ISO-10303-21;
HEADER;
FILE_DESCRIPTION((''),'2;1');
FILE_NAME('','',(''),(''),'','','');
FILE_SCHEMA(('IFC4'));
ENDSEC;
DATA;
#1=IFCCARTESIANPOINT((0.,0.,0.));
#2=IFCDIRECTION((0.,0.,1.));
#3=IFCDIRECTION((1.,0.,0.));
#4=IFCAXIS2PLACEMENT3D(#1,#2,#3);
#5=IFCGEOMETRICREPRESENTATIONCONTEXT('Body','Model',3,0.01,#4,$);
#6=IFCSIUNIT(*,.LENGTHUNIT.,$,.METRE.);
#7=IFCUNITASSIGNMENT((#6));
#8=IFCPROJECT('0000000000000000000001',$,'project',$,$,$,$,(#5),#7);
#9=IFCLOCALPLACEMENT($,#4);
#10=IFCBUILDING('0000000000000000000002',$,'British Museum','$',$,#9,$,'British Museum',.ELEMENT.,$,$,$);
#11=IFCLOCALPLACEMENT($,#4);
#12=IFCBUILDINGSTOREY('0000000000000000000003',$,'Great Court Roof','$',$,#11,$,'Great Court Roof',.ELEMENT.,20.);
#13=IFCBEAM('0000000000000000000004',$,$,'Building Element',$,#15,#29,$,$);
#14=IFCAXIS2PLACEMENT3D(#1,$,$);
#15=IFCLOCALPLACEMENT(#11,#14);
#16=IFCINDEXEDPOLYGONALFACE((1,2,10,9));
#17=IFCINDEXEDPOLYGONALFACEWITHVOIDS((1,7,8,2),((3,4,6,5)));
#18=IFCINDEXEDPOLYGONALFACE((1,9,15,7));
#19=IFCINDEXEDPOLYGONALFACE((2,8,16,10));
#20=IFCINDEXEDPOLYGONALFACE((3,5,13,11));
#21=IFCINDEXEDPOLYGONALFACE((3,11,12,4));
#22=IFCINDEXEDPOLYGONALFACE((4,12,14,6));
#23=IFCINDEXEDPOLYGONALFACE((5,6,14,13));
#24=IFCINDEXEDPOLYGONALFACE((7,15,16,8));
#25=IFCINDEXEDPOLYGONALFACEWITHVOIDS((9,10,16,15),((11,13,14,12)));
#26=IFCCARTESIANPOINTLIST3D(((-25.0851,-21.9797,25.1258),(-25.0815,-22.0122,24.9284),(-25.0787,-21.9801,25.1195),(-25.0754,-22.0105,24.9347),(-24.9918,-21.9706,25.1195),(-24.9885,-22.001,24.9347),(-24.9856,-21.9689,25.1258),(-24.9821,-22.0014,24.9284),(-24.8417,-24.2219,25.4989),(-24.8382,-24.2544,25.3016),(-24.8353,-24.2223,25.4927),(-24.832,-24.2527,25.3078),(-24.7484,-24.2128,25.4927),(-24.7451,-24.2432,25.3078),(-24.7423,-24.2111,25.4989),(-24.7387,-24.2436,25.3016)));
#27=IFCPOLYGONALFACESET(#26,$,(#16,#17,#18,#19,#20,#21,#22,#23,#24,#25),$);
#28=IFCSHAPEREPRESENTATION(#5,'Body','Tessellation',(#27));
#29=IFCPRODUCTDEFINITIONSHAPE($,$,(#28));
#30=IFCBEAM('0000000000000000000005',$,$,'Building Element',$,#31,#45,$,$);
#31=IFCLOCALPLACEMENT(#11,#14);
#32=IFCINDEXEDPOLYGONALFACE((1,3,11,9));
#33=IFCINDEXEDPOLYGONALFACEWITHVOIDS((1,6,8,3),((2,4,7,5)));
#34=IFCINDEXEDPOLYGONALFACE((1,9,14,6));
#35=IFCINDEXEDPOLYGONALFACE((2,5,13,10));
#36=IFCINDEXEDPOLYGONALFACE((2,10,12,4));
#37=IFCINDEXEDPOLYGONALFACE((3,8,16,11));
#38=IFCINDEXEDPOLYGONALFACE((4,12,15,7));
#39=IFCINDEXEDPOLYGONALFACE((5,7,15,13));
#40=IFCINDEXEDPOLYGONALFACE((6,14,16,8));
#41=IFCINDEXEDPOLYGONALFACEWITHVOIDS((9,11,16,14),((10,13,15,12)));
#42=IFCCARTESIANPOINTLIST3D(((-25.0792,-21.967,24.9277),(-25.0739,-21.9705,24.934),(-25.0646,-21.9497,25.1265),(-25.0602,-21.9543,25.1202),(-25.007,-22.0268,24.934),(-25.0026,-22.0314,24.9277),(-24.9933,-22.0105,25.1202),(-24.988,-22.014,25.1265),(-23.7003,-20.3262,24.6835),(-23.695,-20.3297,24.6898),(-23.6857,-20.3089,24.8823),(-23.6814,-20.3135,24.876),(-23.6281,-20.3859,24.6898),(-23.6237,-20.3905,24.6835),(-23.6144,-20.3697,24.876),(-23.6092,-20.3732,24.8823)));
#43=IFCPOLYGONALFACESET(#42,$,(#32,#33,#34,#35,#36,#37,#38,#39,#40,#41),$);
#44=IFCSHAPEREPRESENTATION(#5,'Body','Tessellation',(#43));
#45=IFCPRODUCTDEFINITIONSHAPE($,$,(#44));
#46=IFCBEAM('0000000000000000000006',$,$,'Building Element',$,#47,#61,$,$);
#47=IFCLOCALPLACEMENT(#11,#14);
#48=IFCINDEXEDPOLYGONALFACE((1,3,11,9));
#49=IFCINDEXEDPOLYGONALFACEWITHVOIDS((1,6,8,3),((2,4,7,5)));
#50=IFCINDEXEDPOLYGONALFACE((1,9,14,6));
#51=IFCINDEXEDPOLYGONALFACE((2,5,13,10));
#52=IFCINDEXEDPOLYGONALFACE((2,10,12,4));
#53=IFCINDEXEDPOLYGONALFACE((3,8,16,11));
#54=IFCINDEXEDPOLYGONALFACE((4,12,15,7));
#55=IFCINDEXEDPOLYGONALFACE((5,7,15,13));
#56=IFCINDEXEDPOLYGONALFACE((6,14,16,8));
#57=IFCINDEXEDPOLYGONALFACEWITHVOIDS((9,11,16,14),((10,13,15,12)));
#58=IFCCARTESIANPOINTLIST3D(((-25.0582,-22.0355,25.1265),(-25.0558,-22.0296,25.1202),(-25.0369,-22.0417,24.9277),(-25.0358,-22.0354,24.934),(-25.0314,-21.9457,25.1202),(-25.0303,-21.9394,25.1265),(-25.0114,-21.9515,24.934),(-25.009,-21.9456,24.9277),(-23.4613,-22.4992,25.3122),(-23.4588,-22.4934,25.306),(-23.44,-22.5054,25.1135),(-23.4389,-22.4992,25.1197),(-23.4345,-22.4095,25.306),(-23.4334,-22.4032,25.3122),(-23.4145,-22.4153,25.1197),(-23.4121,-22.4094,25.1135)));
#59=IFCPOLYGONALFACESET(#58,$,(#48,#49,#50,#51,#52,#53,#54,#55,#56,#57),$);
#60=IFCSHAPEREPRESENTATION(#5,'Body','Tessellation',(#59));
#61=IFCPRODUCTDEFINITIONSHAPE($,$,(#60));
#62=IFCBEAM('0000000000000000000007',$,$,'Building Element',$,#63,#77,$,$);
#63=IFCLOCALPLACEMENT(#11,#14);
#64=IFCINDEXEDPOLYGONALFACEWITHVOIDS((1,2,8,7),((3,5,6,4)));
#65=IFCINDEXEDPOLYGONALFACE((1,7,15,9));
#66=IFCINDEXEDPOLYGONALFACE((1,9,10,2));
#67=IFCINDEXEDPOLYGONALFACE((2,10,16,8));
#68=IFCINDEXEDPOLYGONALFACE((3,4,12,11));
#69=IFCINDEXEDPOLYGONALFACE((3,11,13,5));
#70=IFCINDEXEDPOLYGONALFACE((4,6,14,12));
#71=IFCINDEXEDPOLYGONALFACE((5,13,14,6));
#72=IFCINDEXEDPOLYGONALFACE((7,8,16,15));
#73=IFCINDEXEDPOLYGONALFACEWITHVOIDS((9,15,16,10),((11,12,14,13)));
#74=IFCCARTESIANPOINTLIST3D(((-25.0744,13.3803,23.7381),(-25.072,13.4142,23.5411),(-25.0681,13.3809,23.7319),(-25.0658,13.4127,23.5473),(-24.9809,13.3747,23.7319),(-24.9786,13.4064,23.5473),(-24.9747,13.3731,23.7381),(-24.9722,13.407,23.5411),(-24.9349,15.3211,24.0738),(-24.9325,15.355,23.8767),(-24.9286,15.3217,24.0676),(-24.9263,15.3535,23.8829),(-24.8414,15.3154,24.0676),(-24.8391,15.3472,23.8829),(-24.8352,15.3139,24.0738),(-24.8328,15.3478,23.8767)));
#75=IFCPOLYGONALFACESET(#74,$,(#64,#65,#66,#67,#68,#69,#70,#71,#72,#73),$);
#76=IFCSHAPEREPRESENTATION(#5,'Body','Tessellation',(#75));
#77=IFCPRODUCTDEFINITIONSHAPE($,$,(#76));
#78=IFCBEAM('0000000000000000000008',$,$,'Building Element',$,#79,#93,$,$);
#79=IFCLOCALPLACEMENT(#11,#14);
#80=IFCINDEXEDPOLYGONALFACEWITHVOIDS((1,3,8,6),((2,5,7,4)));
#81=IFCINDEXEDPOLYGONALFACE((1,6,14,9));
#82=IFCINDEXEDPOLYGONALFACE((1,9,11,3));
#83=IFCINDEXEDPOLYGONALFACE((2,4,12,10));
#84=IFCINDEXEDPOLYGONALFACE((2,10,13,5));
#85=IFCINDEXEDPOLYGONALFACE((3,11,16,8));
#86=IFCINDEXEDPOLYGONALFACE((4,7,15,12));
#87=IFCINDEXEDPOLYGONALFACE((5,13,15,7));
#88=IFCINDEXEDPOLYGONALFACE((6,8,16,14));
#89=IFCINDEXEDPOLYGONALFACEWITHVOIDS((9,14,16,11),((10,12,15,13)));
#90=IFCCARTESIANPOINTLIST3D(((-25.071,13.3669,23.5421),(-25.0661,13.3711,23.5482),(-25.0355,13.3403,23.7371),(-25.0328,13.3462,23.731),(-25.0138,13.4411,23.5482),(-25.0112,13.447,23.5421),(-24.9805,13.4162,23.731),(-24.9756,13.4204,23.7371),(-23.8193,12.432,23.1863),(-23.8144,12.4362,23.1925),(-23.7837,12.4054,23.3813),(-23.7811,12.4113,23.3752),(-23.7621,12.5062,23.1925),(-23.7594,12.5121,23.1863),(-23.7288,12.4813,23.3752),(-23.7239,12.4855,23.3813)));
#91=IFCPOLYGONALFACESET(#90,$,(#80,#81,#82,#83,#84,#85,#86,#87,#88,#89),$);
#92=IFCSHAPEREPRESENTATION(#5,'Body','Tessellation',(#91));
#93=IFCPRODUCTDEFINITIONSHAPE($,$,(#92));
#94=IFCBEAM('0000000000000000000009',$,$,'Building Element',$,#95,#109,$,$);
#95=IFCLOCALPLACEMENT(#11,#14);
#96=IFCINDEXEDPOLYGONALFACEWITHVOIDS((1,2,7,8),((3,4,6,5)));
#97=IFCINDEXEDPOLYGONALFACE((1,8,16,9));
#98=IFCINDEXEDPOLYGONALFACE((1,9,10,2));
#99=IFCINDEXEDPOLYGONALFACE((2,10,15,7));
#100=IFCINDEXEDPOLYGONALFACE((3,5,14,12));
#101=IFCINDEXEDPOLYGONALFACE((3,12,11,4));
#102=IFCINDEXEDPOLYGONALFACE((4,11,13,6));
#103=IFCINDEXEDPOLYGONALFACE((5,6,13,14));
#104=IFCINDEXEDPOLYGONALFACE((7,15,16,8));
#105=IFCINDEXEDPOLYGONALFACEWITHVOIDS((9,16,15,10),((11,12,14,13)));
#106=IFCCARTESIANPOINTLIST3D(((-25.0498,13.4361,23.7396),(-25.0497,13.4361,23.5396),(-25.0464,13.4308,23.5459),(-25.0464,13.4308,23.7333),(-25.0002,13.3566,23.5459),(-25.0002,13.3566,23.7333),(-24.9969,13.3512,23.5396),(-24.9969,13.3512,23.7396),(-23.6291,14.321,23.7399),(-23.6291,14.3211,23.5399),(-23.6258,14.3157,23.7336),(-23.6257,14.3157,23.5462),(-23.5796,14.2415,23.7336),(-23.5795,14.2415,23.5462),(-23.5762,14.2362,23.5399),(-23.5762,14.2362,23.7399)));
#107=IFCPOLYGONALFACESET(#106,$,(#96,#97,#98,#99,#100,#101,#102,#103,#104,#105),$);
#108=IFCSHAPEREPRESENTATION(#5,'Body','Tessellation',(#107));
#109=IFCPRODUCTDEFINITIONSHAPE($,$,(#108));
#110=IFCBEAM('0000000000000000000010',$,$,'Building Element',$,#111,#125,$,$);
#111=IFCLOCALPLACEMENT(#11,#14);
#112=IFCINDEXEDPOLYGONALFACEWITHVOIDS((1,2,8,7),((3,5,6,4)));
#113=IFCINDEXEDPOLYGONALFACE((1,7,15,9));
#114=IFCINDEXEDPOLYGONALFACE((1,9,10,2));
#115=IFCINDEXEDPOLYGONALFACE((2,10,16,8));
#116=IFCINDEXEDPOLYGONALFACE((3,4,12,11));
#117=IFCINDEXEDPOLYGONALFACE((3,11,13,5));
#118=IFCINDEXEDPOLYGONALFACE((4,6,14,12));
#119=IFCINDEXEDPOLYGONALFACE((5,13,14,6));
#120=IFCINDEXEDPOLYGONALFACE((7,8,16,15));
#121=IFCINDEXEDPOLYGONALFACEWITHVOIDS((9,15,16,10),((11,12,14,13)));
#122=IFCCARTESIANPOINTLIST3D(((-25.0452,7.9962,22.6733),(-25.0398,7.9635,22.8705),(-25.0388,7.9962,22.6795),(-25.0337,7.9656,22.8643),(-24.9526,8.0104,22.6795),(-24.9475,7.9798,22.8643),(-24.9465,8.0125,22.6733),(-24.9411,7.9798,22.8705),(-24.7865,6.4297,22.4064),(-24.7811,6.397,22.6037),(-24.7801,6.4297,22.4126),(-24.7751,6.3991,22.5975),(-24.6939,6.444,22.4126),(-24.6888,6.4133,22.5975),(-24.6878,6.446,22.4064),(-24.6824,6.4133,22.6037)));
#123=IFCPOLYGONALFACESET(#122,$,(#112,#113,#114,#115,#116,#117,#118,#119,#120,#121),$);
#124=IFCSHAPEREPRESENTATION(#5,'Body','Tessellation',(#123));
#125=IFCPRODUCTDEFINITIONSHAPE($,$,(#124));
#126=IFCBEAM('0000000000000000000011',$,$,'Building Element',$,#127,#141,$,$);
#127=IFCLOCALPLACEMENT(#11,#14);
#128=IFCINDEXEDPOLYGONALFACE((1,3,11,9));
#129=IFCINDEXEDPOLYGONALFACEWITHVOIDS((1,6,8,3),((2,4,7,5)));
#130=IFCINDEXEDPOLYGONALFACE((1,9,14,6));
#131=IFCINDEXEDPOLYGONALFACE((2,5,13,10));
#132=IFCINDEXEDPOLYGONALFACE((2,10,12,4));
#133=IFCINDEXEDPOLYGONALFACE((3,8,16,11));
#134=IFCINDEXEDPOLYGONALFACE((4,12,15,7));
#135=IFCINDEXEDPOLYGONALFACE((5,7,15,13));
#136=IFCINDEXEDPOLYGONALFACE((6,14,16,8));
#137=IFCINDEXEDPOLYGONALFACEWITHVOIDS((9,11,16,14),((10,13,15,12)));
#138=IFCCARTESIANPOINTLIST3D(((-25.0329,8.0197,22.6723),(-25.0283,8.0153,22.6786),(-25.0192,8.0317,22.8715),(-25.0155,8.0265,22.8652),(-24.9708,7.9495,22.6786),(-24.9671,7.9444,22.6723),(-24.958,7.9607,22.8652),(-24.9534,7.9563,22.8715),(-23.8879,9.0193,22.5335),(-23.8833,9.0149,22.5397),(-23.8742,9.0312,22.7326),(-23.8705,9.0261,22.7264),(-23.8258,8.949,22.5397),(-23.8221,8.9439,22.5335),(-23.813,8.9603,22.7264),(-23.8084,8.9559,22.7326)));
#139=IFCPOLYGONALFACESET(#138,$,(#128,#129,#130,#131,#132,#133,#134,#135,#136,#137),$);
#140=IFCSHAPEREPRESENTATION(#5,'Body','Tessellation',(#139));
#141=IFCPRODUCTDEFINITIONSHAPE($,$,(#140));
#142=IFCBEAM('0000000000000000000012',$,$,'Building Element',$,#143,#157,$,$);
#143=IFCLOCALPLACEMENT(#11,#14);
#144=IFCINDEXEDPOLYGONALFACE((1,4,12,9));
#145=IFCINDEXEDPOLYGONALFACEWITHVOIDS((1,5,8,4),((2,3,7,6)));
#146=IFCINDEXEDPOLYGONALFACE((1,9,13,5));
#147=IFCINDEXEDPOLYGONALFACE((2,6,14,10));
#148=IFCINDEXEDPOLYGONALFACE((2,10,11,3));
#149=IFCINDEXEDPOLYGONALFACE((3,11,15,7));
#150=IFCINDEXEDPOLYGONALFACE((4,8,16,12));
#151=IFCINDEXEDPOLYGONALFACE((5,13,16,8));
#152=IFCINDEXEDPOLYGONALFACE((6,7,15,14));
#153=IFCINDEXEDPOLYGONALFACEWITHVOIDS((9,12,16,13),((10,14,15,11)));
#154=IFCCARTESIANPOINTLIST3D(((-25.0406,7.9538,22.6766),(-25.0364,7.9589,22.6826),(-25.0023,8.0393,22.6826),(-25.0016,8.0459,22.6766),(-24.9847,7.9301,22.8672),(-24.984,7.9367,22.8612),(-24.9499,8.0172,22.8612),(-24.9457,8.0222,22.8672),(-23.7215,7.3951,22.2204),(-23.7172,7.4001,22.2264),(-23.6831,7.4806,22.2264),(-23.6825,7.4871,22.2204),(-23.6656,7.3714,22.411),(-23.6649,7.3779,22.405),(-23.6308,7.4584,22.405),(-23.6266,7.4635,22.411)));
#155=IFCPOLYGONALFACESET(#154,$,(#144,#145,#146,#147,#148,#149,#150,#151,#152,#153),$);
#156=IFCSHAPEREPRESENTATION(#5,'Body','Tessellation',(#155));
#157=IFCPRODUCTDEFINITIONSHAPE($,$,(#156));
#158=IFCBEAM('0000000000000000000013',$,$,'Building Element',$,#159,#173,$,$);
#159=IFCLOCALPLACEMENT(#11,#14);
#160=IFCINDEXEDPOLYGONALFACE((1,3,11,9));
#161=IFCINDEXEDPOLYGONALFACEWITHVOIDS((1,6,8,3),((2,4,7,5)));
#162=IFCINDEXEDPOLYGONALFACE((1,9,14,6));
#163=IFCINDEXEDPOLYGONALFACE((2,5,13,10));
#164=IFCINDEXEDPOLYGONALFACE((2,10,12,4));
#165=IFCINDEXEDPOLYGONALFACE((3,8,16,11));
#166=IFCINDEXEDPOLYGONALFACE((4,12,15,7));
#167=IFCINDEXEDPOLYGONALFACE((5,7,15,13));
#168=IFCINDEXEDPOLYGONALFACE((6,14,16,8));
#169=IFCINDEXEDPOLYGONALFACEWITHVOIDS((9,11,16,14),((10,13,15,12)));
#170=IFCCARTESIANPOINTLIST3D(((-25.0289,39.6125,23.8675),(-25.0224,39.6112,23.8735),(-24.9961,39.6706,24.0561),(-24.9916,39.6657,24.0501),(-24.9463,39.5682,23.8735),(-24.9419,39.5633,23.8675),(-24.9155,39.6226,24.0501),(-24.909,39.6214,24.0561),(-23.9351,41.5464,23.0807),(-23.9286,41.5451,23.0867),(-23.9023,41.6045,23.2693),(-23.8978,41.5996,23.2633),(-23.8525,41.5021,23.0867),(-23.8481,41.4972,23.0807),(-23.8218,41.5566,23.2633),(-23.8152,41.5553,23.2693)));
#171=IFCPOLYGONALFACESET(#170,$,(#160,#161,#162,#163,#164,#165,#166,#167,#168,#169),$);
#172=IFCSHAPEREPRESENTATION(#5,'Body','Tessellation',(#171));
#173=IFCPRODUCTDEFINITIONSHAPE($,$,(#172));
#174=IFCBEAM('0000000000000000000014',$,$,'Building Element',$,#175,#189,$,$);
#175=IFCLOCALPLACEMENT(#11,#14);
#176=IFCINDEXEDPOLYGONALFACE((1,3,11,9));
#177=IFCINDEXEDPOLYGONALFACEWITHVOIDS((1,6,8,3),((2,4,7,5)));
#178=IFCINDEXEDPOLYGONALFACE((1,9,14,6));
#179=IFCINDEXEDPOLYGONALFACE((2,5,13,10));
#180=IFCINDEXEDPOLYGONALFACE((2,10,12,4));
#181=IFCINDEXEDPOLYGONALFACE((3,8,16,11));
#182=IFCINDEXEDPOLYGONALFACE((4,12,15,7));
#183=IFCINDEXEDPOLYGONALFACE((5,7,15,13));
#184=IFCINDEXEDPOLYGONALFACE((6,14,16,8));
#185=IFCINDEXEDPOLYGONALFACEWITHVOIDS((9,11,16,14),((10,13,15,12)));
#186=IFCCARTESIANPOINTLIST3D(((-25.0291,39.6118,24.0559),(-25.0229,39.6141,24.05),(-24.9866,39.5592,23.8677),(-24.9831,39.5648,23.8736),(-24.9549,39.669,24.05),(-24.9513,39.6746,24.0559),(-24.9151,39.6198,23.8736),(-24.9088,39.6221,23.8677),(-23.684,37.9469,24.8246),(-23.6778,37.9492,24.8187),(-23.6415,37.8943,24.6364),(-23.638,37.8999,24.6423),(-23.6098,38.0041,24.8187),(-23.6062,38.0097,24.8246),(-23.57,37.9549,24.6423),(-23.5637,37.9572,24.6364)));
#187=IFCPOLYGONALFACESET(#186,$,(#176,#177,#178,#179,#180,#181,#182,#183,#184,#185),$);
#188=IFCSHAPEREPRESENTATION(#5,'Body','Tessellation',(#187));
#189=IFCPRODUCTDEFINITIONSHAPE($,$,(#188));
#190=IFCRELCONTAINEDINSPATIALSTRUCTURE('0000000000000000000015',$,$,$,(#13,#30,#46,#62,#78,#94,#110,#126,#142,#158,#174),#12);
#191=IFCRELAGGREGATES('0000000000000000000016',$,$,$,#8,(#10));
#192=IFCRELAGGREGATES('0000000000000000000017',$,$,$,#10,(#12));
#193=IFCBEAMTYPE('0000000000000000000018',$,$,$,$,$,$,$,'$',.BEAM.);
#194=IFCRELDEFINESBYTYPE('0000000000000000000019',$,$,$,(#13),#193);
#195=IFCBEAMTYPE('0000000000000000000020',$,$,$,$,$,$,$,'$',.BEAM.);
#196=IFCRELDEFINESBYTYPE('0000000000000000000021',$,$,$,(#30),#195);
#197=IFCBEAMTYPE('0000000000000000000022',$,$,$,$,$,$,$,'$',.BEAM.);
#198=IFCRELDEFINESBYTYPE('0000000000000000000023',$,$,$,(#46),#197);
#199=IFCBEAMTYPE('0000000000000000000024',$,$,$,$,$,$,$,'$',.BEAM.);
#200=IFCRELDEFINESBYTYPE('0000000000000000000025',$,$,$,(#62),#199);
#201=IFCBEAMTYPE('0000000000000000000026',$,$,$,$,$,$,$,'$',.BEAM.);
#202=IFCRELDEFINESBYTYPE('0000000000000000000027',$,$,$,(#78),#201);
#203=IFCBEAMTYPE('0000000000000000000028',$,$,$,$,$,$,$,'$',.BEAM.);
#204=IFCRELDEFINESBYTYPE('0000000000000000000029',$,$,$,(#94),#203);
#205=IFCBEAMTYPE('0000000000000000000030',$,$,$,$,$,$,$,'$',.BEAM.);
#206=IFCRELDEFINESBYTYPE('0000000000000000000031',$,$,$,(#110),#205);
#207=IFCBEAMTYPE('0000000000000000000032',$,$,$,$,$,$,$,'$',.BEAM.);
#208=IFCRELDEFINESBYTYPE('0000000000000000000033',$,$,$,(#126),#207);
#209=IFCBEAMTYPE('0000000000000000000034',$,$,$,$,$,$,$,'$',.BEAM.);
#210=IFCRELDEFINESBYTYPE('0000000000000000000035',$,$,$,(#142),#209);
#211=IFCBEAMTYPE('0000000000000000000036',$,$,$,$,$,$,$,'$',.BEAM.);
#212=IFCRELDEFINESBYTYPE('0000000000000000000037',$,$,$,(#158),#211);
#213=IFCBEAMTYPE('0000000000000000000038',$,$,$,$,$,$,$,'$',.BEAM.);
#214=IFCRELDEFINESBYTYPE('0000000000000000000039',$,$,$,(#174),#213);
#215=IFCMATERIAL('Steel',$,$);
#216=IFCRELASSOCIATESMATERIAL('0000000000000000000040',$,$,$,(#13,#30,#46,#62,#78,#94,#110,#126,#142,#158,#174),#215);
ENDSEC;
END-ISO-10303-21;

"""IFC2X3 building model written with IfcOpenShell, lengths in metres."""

from ifc_helpers import new_model, si_unit, frame, origin_with_axes, origin_2d, place, context, project, spatial, hollow_rectangle, extrude, material, type_object, element, save


model = new_model("IFC2X3")

# Units and contexts
model_context = context("Model", 3, precision=0.01, world=origin_with_axes(), identifier="Body")
ifc_project = project(units=[si_unit("LENGTHUNIT", "METRE")], contexts=[model_context])

# Building, storey
building_placement = place(None, origin_with_axes())
building = spatial("IfcBuilding", under=ifc_project, at=building_placement, Name="British Museum", Description="$", LongName="British Museum", CompositionType="ELEMENT")
storey_placement = place(None, origin_with_axes())
storey = spatial("IfcBuildingStorey", under=building, at=storey_placement, Name="Great Court Roof", Description="$", LongName="Great Court Roof", CompositionType="ELEMENT", Elevation=20.0)

# Beams
ifc_material = material(Name="Steel")
beam_type_1 = type_object("IfcBeamType", ElementType="$", PredefinedType="BEAM")
beam_1_placement = place(None, origin_with_axes())
element("IfcBeam", 1, at=beam_1_placement, inside=storey, type_object=beam_type_1, material=ifc_material, Description="Building Element", context=model_context, shape_type="SweptSolid", body=[
    extrude(hollow_rectangle(XDim=0.1, YDim=0.2, WallThickness=0.0063, InnerFilletRadius=-0.0063, OuterFilletRadius=0.0, at=origin_2d()), frame((-25.0336, -21.9905, 25.0271), z_axis=(0.106465, -0.980829, 0.163215), x_axis=(0.99416, 0.107912, 0.0)), (0.0, 0.0, 1.0), 2.286),
])
beam_type_2 = type_object("IfcBeamType", ElementType="$", PredefinedType="BEAM")
beam_2_placement = place(None, origin_with_axes())
element("IfcBeam", 2, at=beam_2_placement, inside=storey, type_object=beam_type_2, material=ifc_material, Description="Building Element", context=model_context, shape_type="SweptSolid", body=[
    extrude(hollow_rectangle(XDim=0.1, YDim=0.2, WallThickness=0.0063, InnerFilletRadius=-0.0063, OuterFilletRadius=0.0, at=origin_2d()), frame((-25.0336, -21.9905, 25.0271), z_axis=(0.639206, 0.760658, -0.113205), x_axis=(-0.765579, 0.643342, 0.0)), (0.0, 0.0, 1.0), 2.1572),
])
beam_type_3 = type_object("IfcBeamType", ElementType="$", PredefinedType="BEAM")
beam_3_placement = place(None, origin_with_axes())
element("IfcBeam", 3, at=beam_3_placement, inside=storey, type_object=beam_type_3, material=ifc_material, Description="Building Element", context=model_context, shape_type="SweptSolid", body=[
    extrude(hollow_rectangle(XDim=0.1, YDim=0.2, WallThickness=0.0063, InnerFilletRadius=-0.0063, OuterFilletRadius=0.0, at=origin_2d()), frame((-25.0336, -21.9905, 25.0271), z_axis=(0.954384, -0.277177, 0.111014), x_axis=(0.278901, 0.96032, 0.0)), (0.0, 0.0, 1.0), 1.6733),
])
beam_type_4 = type_object("IfcBeamType", ElementType="$", PredefinedType="BEAM")
beam_4_placement = place(None, origin_with_axes())
element("IfcBeam", 4, at=beam_4_placement, inside=storey, type_object=beam_type_4, material=ifc_material, Description="Building Element", context=model_context, shape_type="SweptSolid", body=[
    extrude(hollow_rectangle(XDim=0.1, YDim=0.2, WallThickness=0.0063, InnerFilletRadius=-0.0063, OuterFilletRadius=0.0, at=origin_2d()), frame((-25.0233, 13.3937, 23.6396), z_axis=(0.070637, 0.98291, 0.169993), x_axis=(-0.997428, 0.07168, 0.0)), (0.0, 0.0, 1.0), 1.9745),
])
beam_type_5 = type_object("IfcBeamType", ElementType="$", PredefinedType="BEAM")
beam_5_placement = place(None, origin_with_axes())
element("IfcBeam", 5, at=beam_5_placement, inside=storey, type_object=beam_type_5, material=ifc_material, Description="Building Element", context=model_context, shape_type="SweptSolid", body=[
    extrude(hollow_rectangle(XDim=0.1, YDim=0.2, WallThickness=0.0063, InnerFilletRadius=-0.0063, OuterFilletRadius=0.0, at=origin_2d()), frame((-25.0233, 13.3937, 23.6396), z_axis=(0.781202, -0.583463, -0.222024), x_axis=(0.598398, 0.801199, 0.0)), (0.0, 0.0, 1.0), 1.6023),
])
beam_type_6 = type_object("IfcBeamType", ElementType="$", PredefinedType="BEAM")
beam_6_placement = place(None, origin_with_axes())
element("IfcBeam", 6, at=beam_6_placement, inside=storey, type_object=beam_type_6, material=ifc_material, Description="Building Element", context=model_context, shape_type="SweptSolid", body=[
    extrude(hollow_rectangle(XDim=0.1, YDim=0.2, WallThickness=0.0063, InnerFilletRadius=-0.0063, OuterFilletRadius=0.0, at=origin_2d()), frame((-25.0233, 13.3937, 23.6396), z_axis=(0.8488, 0.528715, 0.000194), x_axis=(-0.528715, 0.8488, 0.0)), (0.0, 0.0, 1.0), 1.6737),
])
beam_type_7 = type_object("IfcBeamType", ElementType="$", PredefinedType="BEAM")
beam_7_placement = place(None, origin_with_axes())
element("IfcBeam", 7, at=beam_7_placement, inside=storey, type_object=beam_type_7, material=ifc_material, Description="Building Element", context=model_context, shape_type="SweptSolid", body=[
    extrude(hollow_rectangle(XDim=0.1, YDim=0.2, WallThickness=0.0063, InnerFilletRadius=-0.0063, OuterFilletRadius=0.0, at=origin_2d()), frame((-24.9931, 7.988, 22.7719), z_axis=(0.160668, -0.97299, -0.16576), x_axis=(0.986639, 0.162921, 0.0)), (0.0, 0.0, 1.0), 1.61),
])
beam_type_8 = type_object("IfcBeamType", ElementType="$", PredefinedType="BEAM")
beam_8_placement = place(None, origin_with_axes())
element("IfcBeam", 8, at=beam_8_placement, inside=storey, type_object=beam_type_8, material=ifc_material, Description="Building Element", context=model_context, shape_type="SweptSolid", body=[
    extrude(hollow_rectangle(XDim=0.1, YDim=0.2, WallThickness=0.0063, InnerFilletRadius=-0.0063, OuterFilletRadius=0.0, at=origin_2d()), frame((-24.9931, 7.988, 22.7719), z_axis=(0.750202, 0.654918, -0.090989), x_axis=(-0.657646, 0.753327, 0.0)), (0.0, 0.0, 1.0), 1.5262),
])
beam_type_9 = type_object("IfcBeamType", ElementType="$", PredefinedType="BEAM")
beam_9_placement = place(None, origin_with_axes())
element("IfcBeam", 9, at=beam_9_placement, inside=storey, type_object=beam_type_9, material=ifc_material, Description="Building Element", context=model_context, shape_type="SweptSolid", body=[
    extrude(hollow_rectangle(XDim=0.1, YDim=0.2, WallThickness=0.0063, InnerFilletRadius=-0.0063, OuterFilletRadius=0.0, at=origin_2d()), frame((-24.9931, 7.988, 22.7719), z_axis=(0.877391, -0.371636, -0.303433), x_axis=(0.390025, 0.920804, 0.0)), (0.0, 0.0, 1.0), 1.5035),
])
beam_type_10 = type_object("IfcBeamType", ElementType="$", PredefinedType="BEAM")
beam_10_placement = place(None, origin_with_axes())
element("IfcBeam", 10, at=beam_10_placement, inside=storey, type_object=beam_type_10, material=ifc_material, Description="Building Element", context=model_context, shape_type="SweptSolid", body=[
    extrude(hollow_rectangle(XDim=0.1, YDim=0.2, WallThickness=0.0063, InnerFilletRadius=-0.0063, OuterFilletRadius=0.0, at=origin_2d()), frame((-24.969, 39.6169, 23.9618), z_axis=(0.464055, 0.820501, -0.333814), x_axis=(-0.870429, 0.492294, 0.0)), (0.0, 0.0, 1.0), 2.357),
])
beam_type_11 = type_object("IfcBeamType", ElementType="$", PredefinedType="BEAM")
beam_11_placement = place(None, origin_with_axes())
element("IfcBeam", 11, at=beam_11_placement, inside=storey, type_object=beam_type_11, material=ifc_material, Description="Building Element", context=model_context, shape_type="SweptSolid", body=[
    extrude(hollow_rectangle(XDim=0.1, YDim=0.2, WallThickness=0.0063, InnerFilletRadius=-0.0063, OuterFilletRadius=0.0, at=origin_2d()), frame((-24.969, 39.6169, 23.9618), z_axis=(0.591453, -0.732071, 0.338018), x_axis=(0.777856, 0.628443, 0.0)), (0.0, 0.0, 1.0), 2.2742),
])

save(model, "model.ifc")
